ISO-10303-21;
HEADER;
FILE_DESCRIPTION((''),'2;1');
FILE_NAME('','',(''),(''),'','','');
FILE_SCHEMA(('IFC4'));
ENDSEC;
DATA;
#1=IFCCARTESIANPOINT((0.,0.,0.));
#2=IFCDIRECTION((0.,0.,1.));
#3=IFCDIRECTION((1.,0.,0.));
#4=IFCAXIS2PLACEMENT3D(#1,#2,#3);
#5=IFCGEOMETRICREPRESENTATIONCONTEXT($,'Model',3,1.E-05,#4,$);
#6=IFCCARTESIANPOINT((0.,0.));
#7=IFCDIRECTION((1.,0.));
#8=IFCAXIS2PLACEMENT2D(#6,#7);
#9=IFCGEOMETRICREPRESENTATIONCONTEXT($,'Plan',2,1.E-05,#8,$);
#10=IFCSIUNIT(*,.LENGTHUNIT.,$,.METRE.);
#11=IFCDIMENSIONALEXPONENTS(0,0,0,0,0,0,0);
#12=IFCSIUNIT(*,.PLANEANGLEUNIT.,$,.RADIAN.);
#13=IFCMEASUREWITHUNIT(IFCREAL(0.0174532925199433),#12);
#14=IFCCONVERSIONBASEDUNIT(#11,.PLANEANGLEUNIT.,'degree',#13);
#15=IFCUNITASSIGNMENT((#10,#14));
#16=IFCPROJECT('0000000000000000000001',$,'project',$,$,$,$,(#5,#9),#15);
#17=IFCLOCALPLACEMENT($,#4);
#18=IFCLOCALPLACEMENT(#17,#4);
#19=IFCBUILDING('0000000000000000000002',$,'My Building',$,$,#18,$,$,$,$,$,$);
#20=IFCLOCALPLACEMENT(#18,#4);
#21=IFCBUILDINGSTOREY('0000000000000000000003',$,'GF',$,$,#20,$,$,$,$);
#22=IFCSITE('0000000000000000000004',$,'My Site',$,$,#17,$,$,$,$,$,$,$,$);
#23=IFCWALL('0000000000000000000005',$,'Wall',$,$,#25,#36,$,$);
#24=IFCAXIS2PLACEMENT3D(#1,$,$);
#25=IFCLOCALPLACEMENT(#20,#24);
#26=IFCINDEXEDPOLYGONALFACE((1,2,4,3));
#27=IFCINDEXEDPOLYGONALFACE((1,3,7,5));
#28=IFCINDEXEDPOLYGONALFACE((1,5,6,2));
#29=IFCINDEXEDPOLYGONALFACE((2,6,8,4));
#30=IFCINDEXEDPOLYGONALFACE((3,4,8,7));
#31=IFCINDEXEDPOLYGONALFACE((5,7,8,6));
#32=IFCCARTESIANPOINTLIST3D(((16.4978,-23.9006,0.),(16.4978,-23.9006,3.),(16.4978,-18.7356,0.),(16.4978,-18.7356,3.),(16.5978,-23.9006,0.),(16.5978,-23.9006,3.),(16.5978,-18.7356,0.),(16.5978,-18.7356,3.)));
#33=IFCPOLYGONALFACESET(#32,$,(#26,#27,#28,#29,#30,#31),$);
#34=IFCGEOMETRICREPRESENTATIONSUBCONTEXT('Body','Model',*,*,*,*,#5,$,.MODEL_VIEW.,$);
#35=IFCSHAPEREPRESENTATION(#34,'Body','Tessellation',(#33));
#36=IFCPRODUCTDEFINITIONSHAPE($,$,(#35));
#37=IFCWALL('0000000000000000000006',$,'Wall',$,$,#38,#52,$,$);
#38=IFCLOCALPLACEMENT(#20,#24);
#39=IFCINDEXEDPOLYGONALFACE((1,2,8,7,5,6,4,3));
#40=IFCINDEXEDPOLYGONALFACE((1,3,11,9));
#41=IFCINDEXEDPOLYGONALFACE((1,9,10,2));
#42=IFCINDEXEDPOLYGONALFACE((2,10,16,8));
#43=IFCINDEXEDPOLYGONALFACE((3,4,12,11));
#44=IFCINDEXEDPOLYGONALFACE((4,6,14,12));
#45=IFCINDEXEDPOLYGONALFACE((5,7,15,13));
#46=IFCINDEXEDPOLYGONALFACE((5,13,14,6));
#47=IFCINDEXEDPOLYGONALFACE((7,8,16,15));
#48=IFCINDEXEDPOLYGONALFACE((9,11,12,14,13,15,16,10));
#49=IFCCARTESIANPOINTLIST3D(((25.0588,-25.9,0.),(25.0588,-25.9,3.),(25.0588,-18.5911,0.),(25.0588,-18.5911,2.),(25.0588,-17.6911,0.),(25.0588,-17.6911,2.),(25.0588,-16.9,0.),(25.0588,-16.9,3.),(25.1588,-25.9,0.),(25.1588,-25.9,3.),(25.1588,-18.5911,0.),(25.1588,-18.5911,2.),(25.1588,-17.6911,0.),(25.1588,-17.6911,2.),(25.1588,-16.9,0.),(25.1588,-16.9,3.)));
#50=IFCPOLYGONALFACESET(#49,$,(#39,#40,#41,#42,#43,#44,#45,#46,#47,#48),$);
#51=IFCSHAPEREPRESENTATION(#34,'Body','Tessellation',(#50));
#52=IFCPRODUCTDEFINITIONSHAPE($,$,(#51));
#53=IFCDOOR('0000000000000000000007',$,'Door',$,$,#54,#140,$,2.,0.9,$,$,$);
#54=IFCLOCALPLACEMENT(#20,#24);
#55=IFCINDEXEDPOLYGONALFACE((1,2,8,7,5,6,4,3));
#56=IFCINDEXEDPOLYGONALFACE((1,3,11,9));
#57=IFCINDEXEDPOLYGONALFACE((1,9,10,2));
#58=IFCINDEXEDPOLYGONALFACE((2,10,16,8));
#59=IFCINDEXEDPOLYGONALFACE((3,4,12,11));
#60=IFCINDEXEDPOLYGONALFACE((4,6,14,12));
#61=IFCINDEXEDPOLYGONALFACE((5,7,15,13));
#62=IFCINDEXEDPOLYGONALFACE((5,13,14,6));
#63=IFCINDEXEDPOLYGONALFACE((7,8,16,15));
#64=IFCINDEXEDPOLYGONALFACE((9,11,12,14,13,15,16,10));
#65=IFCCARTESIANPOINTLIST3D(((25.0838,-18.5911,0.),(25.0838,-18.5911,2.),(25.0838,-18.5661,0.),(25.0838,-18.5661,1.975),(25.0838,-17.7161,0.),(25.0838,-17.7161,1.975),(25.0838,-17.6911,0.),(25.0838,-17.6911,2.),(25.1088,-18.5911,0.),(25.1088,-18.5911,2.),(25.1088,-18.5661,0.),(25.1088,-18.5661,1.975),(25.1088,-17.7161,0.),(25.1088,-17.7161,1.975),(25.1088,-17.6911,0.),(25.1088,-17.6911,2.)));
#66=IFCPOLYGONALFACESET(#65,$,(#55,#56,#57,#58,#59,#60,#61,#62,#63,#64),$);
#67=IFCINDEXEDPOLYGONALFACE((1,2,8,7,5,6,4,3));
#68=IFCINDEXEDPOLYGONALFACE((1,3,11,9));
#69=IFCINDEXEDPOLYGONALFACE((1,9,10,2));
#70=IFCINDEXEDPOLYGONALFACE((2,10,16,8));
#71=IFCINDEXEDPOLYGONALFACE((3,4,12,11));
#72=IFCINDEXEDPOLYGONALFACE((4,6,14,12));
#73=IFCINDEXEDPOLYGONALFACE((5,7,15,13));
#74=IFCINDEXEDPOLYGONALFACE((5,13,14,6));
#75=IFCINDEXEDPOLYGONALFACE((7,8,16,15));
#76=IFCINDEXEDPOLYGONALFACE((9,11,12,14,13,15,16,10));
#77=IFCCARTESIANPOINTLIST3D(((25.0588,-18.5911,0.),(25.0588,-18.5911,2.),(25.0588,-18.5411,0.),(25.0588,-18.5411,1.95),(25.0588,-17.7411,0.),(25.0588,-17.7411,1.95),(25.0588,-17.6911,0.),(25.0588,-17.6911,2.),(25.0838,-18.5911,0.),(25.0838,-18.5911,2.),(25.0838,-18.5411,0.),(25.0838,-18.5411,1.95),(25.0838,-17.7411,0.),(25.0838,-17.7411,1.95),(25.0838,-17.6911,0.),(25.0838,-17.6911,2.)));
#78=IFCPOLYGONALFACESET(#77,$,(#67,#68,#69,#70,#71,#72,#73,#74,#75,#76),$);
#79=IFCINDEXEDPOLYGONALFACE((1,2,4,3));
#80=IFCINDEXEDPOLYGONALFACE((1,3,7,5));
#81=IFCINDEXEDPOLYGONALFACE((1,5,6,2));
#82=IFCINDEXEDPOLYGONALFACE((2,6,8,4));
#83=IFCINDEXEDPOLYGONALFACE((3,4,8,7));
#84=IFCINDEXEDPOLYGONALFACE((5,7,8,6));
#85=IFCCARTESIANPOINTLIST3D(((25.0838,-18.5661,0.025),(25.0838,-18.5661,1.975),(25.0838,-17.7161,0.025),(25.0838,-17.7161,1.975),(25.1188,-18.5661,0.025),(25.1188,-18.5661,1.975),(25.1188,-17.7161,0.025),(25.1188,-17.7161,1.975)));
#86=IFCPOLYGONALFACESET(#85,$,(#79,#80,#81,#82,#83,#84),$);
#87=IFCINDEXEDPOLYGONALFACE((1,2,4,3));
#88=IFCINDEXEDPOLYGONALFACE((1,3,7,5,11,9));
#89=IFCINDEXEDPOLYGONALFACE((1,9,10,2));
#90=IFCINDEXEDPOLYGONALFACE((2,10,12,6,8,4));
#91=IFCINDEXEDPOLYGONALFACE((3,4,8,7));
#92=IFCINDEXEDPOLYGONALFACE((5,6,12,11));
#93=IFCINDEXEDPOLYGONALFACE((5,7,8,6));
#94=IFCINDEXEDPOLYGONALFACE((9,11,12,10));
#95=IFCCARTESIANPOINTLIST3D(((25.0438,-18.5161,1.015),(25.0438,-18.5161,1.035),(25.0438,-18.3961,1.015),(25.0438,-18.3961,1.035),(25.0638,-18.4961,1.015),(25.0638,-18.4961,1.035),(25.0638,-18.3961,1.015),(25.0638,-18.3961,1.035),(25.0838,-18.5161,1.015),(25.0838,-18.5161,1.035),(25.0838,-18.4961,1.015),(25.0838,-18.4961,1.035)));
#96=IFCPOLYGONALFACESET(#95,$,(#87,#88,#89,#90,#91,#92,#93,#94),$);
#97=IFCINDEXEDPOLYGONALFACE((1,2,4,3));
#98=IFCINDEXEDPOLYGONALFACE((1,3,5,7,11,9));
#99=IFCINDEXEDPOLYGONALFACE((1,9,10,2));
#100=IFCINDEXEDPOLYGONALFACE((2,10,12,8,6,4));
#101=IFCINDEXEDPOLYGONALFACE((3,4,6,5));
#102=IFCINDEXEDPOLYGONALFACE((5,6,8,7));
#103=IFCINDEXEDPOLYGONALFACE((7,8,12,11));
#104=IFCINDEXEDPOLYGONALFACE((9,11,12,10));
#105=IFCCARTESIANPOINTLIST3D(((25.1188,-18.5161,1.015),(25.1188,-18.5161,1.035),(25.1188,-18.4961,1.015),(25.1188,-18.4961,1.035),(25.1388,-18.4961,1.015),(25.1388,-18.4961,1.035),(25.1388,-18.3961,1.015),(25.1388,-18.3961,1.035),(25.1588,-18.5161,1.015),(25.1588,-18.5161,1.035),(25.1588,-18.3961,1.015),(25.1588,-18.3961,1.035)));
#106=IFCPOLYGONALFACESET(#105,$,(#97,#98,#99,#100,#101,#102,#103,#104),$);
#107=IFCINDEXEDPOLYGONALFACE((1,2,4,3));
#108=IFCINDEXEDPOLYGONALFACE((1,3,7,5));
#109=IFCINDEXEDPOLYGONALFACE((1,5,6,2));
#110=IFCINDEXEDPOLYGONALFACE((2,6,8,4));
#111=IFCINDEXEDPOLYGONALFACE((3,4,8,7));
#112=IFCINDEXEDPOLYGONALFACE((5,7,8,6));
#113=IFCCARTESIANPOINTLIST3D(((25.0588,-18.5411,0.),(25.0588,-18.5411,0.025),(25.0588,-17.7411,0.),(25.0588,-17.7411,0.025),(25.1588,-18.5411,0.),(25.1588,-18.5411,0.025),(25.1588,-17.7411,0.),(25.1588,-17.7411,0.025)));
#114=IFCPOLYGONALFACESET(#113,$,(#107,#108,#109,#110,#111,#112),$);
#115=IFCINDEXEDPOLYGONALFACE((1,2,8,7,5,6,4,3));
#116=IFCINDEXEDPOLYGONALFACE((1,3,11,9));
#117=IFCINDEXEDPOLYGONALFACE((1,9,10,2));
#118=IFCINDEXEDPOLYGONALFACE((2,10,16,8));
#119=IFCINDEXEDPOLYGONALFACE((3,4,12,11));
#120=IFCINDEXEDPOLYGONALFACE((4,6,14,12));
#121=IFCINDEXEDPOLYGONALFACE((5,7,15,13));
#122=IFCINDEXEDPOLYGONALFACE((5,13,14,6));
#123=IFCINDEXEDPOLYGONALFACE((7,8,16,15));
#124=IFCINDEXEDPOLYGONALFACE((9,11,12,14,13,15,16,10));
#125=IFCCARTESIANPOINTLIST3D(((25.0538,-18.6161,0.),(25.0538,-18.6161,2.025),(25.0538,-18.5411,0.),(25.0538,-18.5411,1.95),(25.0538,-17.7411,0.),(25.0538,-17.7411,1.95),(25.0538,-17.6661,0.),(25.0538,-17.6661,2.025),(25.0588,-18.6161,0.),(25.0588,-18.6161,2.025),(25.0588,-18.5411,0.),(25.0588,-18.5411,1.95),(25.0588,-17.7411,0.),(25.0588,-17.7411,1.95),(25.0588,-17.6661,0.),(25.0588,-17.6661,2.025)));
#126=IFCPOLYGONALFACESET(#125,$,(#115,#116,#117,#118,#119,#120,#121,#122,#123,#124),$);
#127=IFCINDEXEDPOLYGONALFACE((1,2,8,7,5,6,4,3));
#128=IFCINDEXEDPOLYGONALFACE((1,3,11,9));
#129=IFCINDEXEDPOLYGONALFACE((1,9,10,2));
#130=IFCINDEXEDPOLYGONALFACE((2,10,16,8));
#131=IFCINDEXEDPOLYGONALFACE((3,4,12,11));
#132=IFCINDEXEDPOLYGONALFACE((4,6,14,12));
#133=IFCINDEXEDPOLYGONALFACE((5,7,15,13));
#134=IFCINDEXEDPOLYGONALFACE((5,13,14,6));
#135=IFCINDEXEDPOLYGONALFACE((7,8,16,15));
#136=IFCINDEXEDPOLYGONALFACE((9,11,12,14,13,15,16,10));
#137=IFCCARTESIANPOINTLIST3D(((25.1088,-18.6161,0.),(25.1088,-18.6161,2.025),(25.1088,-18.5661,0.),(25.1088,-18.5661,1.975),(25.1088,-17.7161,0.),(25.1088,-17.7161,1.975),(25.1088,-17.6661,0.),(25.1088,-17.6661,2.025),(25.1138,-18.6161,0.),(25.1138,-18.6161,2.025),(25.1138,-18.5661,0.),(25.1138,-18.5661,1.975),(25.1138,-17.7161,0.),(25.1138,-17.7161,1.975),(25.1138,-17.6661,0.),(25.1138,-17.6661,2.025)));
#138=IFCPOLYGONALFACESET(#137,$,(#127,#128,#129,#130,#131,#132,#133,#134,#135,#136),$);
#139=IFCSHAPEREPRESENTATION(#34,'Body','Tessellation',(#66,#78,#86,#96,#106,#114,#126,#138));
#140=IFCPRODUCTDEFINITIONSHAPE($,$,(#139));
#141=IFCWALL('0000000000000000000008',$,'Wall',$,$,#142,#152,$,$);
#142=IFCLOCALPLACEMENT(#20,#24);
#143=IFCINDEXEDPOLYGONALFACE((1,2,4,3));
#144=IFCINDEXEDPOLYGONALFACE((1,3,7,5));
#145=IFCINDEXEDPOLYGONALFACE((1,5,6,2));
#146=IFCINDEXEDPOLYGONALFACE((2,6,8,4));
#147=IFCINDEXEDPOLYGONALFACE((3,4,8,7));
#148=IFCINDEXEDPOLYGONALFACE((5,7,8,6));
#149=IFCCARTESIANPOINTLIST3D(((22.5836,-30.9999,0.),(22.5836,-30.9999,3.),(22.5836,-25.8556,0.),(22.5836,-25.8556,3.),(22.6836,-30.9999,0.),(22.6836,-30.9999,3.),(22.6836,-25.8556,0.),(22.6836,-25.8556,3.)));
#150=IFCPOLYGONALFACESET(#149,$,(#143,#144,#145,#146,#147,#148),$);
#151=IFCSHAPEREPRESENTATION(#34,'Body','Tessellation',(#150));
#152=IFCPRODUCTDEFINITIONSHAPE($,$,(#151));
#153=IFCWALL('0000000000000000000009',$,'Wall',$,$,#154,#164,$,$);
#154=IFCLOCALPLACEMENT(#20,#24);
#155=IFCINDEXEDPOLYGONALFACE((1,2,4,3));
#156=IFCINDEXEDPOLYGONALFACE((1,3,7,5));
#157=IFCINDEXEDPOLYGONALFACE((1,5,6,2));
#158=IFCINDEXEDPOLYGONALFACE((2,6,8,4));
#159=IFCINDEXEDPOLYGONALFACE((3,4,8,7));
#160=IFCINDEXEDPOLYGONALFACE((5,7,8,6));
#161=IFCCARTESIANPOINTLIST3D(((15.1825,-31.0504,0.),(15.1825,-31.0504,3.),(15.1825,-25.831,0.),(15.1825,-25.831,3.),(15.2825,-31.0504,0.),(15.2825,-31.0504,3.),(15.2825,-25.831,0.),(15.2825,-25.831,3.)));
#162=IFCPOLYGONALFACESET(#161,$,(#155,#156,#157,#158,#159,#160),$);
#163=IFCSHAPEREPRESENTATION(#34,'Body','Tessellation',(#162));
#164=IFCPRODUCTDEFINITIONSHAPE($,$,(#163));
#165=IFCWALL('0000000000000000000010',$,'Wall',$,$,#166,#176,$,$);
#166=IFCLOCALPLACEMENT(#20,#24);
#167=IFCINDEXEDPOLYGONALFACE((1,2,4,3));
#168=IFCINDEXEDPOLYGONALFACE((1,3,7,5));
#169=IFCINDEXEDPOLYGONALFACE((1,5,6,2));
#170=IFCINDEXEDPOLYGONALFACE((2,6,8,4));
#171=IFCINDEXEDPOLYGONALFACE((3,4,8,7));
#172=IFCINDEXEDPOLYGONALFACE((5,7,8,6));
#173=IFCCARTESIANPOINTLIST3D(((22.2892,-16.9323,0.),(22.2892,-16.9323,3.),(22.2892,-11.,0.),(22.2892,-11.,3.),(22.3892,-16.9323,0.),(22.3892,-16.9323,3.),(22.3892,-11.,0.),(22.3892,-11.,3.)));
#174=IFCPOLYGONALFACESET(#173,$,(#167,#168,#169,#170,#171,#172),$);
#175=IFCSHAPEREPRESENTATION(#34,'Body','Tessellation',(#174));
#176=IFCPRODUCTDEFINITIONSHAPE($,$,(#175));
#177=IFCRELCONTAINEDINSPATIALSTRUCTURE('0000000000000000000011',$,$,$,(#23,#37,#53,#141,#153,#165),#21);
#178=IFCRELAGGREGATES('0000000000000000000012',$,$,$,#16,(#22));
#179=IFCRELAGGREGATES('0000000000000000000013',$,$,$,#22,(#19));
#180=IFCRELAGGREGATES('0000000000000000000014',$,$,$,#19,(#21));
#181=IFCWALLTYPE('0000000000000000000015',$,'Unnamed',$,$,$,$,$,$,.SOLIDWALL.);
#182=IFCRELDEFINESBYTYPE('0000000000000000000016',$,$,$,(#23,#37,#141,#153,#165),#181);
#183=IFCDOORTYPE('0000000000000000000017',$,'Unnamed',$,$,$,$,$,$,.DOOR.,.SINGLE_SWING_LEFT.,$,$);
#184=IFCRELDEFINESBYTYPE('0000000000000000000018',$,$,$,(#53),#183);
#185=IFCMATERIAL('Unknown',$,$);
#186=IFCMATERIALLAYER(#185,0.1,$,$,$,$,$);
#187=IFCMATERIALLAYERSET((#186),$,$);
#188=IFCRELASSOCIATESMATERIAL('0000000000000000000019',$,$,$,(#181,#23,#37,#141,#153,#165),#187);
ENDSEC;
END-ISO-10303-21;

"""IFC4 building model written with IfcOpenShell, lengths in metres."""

from ifc_helpers import new_model, entity, si_unit, converted_unit, frame, origin_with_axes, origin_2d_with_axis, place, context, subcontext, project, spatial, line, indexed_curve, outline, extrude, shape, source, transform, mapped, material, layer, layer_set, layer_usage, type_object, type_shapes, element, fill, save


model = new_model("IFC4")

# Units and contexts
model_context = context("Model", 3, precision=1e-05, world=origin_with_axes())
plan_context = context("Plan", 2, precision=1e-05, world=origin_2d_with_axis())
body_context_1 = subcontext(model_context, "Body", "Model", "MODEL_VIEW")
body_context_2 = subcontext(plan_context, "Body", "Plan", "PLAN_VIEW")
ifc_project = project(units=[si_unit("LENGTHUNIT", "METRE"), converted_unit("PLANEANGLEUNIT", "degree", entity("IfcReal", 0.0174532925199433), si_unit("PLANEANGLEUNIT", "RADIAN"), dimensions=[0, 0, 0, 0, 0, 0, 0])], contexts=[model_context, plan_context])

# Site, building, storey
site_placement = place(None, origin_with_axes())
site = spatial("IfcSite", under=ifc_project, at=site_placement, Name="My Site")
building_placement = place(site_placement, origin_with_axes())
building = spatial("IfcBuilding", under=site, at=building_placement, Name="My Building")
storey_placement = place(building_placement, origin_with_axes())
storey = spatial("IfcBuildingStorey", under=building, at=storey_placement, Name="GF")

# Shared definitions
ifc_material = material(Name="Unknown")
ifc_layer = layer(ifc_material, 0.1)
ifc_layer_set = layer_set([ifc_layer])
wall_type = type_object("IfcWallType", Name="Unnamed", PredefinedType="SOLIDWALL", material=ifc_layer_set)

# Shared definitions
shared_shape_1 = source(origin_with_axes(), body_context_1, "Body", "SweptSolid", [
    extrude(outline(indexed_curve([(0.0, 0.0), (0.9, 0.0), (0.9, 2.0), (0.0, 2.0)], segments=[line(1, 2, 3, 4, 1)])), frame((0.0, -0.6, 0.0), z_axis=(0.0, -1.0, 0.0), x_axis=(1.0, 0.0, 0.0)), (0.0, 0.0, -1.0), 1.2),
])
door_type = type_object("IfcDoorType", Name="Unnamed", OperationType="SINGLE_SWING_LEFT", PredefinedType="DOOR")
shared_shape_2 = source(origin_with_axes(), body_context_1, "Body", "SweptSolid", [
    extrude(outline(indexed_curve([(0.0, 0.0), (0.0, 2.0), (0.9, 2.0), (0.9, 0.0), (0.875, 0.0), (0.875, 1.975), (0.025, 1.975), (0.025, 0.0)], segments=[line(1, 2, 3, 4, 5, 6, 7, 8, 1)])), frame((0.0, 0.025, 0.0), z_axis=(0.0, -1.0, 0.0), x_axis=(1.0, 0.0, 0.0)), (0.0, 0.0, -1.0), 0.025),
    extrude(outline(indexed_curve([(0.0, 0.0), (0.0, 2.0), (0.9, 2.0), (0.9, 0.0), (0.85, 0.0), (0.85, 1.95), (0.05, 1.95), (0.05, 0.0)], segments=[line(1, 2, 3, 4, 5, 6, 7, 8, 1)])), frame((0.0, 0.0, 0.0), z_axis=(0.0, -1.0, 0.0), x_axis=(1.0, 0.0, 0.0)), (0.0, 0.0, -1.0), 0.025),
    extrude(outline(indexed_curve([(0.0, 0.0), (0.85, 0.0), (0.85, 0.035), (0.0, 0.035)], segments=[line(1, 2, 3, 4, 1)])), frame((0.025, 0.025, 0.025), z_axis=(0.0, 0.0, 1.0), x_axis=(1.0, 0.0, 0.0)), (0.0, 0.0, 1.0), 1.95),
    extrude(outline(indexed_curve([(0.0, 0.0), (0.0, -0.04), (-0.12, -0.04), (-0.12, -0.02), (-0.02, -0.02), (-0.02, 0.0)], segments=[line(1, 2, 3, 4, 5, 6, 1)])), frame((0.825, 0.025, 1.015), z_axis=(0.0, 0.0, 1.0), x_axis=(1.0, 0.0, 0.0)), (0.0, 0.0, 1.0), 0.02),
    extrude(outline(indexed_curve([(0.0, 0.0), (0.0, 0.04), (-0.12, 0.04), (-0.12, 0.02), (-0.02, 0.02), (-0.02, 0.0)], segments=[line(1, 2, 3, 4, 5, 6, 1)])), frame((0.825, 0.06, 1.015), z_axis=(0.0, 0.0, 1.0), x_axis=(1.0, 0.0, 0.0)), (0.0, 0.0, 1.0), 0.02),
    extrude(outline(indexed_curve([(0.0, 0.0), (0.8, 0.0), (0.8, 0.1), (0.0, 0.1)], segments=[line(1, 2, 3, 4, 1)])), frame((0.05, 0.0, 0.0), z_axis=(0.0, 0.0, 1.0), x_axis=(1.0, 0.0, 0.0)), (0.0, 0.0, 1.0), 0.025),
    extrude(outline(indexed_curve([(0.0, 0.0), (0.0, 2.025), (0.95, 2.025), (0.95, 0.0), (0.875, 0.0), (0.875, 1.95), (0.075, 1.95), (0.075, 0.0)], segments=[line(1, 2, 3, 4, 5, 6, 7, 8, 1)])), frame((-0.025, -0.005, 0.0), z_axis=(0.0, -1.0, 0.0), x_axis=(1.0, 0.0, 0.0)), (0.0, 0.0, -1.0), 0.005),
    extrude(outline(indexed_curve([(0.0, 0.0), (0.0, 2.025), (0.95, 2.025), (0.95, 0.0), (0.9, 0.0), (0.9, 1.975), (0.05, 1.975), (0.05, 0.0)], segments=[line(1, 2, 3, 4, 5, 6, 7, 8, 1)])), frame((-0.025, 0.05, 0.0), z_axis=(0.0, -1.0, 0.0), x_axis=(1.0, 0.0, 0.0)), (0.0, 0.0, -1.0), 0.005),
])
shared_shape_3 = source(origin_with_axes(), body_context_2, "Body", "Curve2D", [
    entity("IfcIndexedPolyCurve", entity("IfcCartesianPointList2D", [[0.0, 0.0], [0.0, 0.05], [0.025, 0.05], [0.025, 0.025], [0.05, 0.025], [0.05, 0.0]]), [entity("IfcLineIndex", [1, 2, 3, 4, 5, 6, 1])]),
    entity("IfcIndexedPolyCurve", entity("IfcCartesianPointList2D", [[0.9, 0.0], [0.9, 0.05], [0.875, 0.05], [0.875, 0.025], [0.85, 0.025], [0.85, 0.0]]), [entity("IfcLineIndex", [1, 2, 3, 4, 5, 6, 1])]),
    entity("IfcTrimmedCurve", entity("IfcEllipse", entity("IfcAxis2Placement2D", entity("IfcCartesianPoint", [0.06, 0.05]), entity("IfcDirection", [1.0, 0.0])), 0.815, 0.85), [entity("IfcCartesianPoint", [0.875, 0.05])], [entity("IfcCartesianPoint", [0.06, 0.9])], True, "CARTESIAN"),
    entity("IfcIndexedPolyCurve", entity("IfcCartesianPointList2D", [[0.025, 0.05], [0.06, 0.05], [0.06, 0.9], [0.025, 0.9]]), [entity("IfcLineIndex", [1, 2, 3, 4, 1])]),
])
type_shapes(door_type, [shared_shape_2, shared_shape_3])

# Wall
ifc_layer_usage_1 = layer_usage(ifc_layer_set, "AXIS2", "POSITIVE", 0.0)
wall_1_placement = place(storey_placement, frame((16.4978, -18.7356, 0.0), z_axis=(0.0, 0.0, 1.0), x_axis=(0.0, -1.0, 0.0)))
element("IfcWall", 1, at=wall_1_placement, inside=storey, type_object=wall_type, material=ifc_layer_usage_1, Name="Wall", context=body_context_1, shape_type="SweptSolid", body=[
    extrude(outline(indexed_curve([(0.0, 0.0), (0.0, 0.1), (5.1651, 0.1), (5.1651, 0.0)], segments=[line(1, 2, 3, 4, 1)])), origin_with_axes(), (0.0, 0.0, 1.0), 3.0),
])

# Wall, opening, door
ifc_layer_usage_2 = layer_usage(ifc_layer_set, "AXIS2", "POSITIVE", 0.0)
wall_2_placement = place(storey_placement, frame((25.0588, -16.9, 0.0), z_axis=(0.0, 0.0, 1.0), x_axis=(0.0, -1.0, 0.0)))
wall_2 = element("IfcWall", 2, at=wall_2_placement, inside=storey, type_object=wall_type, material=ifc_layer_usage_2, Name="Wall", context=body_context_1, shape_type="SweptSolid", body=[
    extrude(outline(indexed_curve([(0.0, 0.0), (0.0, 0.1), (9.0, 0.1), (9.0, 0.0)], segments=[line(1, 2, 3, 4, 1)])), origin_with_axes(), (0.0, 0.0, 1.0), 3.0),
])
opening_1_placement = place(wall_2_placement, frame((0.7911, 0.0, 0.0), z_axis=(0.0, 0.0, 1.0), x_axis=(1.0, 0.0, 0.0)))
opening_1 = element("IfcOpeningElement", 3, at=opening_1_placement, cuts=wall_2, PredefinedType="OPENING", context=body_context_1, shape_type="MappedRepresentation", body=[
    mapped(shared_shape_1, transform((0.0, 0.0, 0.0), x_axis=(1.0, 0.0, 0.0), y_axis=(0.0, 1.0, 0.0), z_axis=(0.0, 0.0, 1.0), scale=1.0)),
])
door_1_placement = place(opening_1_placement, frame((0.0, 0.0, 0.0), z_axis=(0.0, 0.0, 1.0), x_axis=(1.0, 0.0, 0.0)))
door_1 = element("IfcDoor", 4, at=door_1_placement, inside=storey, type_object=door_type, Name="Door", OverallHeight=2.0, OverallWidth=0.9, shapes=[
    shape(body_context_1, "Body", "MappedRepresentation", [mapped(shared_shape_2, transform((0.0, 0.0, 0.0), x_axis=(1.0, 0.0, 0.0), y_axis=(0.0, 1.0, 0.0), z_axis=(0.0, 0.0, 1.0), scale=1.0))]),
    shape(body_context_2, "Body", "MappedRepresentation", [mapped(shared_shape_3, transform((0.0, 0.0, 0.0), x_axis=(1.0, 0.0, 0.0), y_axis=(0.0, 1.0, 0.0), z_axis=(0.0, 0.0, 1.0), scale=1.0))]),
])
fill(opening_1, door_1)

# Walls
ifc_layer_usage_3 = layer_usage(ifc_layer_set, "AXIS2", "POSITIVE", 0.0)
wall_3_placement = place(storey_placement, frame((22.5836, -25.8556, 0.0), z_axis=(0.0, 0.0, 1.0), x_axis=(0.0, -1.0, 0.0)))
element("IfcWall", 5, at=wall_3_placement, inside=storey, type_object=wall_type, material=ifc_layer_usage_3, Name="Wall", context=body_context_1, shape_type="SweptSolid", body=[
    extrude(outline(indexed_curve([(0.0, 0.0), (0.0, 0.1), (5.1443, 0.1), (5.1443, 0.0)], segments=[line(1, 2, 3, 4, 1)])), origin_with_axes(), (0.0, 0.0, 1.0), 3.0),
])
ifc_layer_usage_4 = layer_usage(ifc_layer_set, "AXIS2", "POSITIVE", 0.0)
wall_4_placement = place(storey_placement, frame((15.1825, -25.831, 0.0), z_axis=(0.0, 0.0, 1.0), x_axis=(0.0, -1.0, 0.0)))
element("IfcWall", 6, at=wall_4_placement, inside=storey, type_object=wall_type, material=ifc_layer_usage_4, Name="Wall", context=body_context_1, shape_type="SweptSolid", body=[
    extrude(outline(indexed_curve([(0.0, 0.0), (0.0, 0.1), (5.2194, 0.1), (5.2194, 0.0)], segments=[line(1, 2, 3, 4, 1)])), origin_with_axes(), (0.0, 0.0, 1.0), 3.0),
])
ifc_layer_usage_5 = layer_usage(ifc_layer_set, "AXIS2", "POSITIVE", 0.0)
wall_5_placement = place(storey_placement, frame((22.3892, -16.9323, 0.0), z_axis=(0.0, 0.0, 1.0), x_axis=(0.0, 1.0, 0.0)))
element("IfcWall", 7, at=wall_5_placement, inside=storey, type_object=wall_type, material=ifc_layer_usage_5, Name="Wall", context=body_context_1, shape_type="SweptSolid", body=[
    extrude(outline(indexed_curve([(0.0, 0.0), (0.0, 0.1), (5.9323, 0.1), (5.9323, 0.0)], segments=[line(1, 2, 3, 4, 1)])), origin_with_axes(), (0.0, 0.0, 1.0), 3.0),
])

save(model, "model.ifc")
